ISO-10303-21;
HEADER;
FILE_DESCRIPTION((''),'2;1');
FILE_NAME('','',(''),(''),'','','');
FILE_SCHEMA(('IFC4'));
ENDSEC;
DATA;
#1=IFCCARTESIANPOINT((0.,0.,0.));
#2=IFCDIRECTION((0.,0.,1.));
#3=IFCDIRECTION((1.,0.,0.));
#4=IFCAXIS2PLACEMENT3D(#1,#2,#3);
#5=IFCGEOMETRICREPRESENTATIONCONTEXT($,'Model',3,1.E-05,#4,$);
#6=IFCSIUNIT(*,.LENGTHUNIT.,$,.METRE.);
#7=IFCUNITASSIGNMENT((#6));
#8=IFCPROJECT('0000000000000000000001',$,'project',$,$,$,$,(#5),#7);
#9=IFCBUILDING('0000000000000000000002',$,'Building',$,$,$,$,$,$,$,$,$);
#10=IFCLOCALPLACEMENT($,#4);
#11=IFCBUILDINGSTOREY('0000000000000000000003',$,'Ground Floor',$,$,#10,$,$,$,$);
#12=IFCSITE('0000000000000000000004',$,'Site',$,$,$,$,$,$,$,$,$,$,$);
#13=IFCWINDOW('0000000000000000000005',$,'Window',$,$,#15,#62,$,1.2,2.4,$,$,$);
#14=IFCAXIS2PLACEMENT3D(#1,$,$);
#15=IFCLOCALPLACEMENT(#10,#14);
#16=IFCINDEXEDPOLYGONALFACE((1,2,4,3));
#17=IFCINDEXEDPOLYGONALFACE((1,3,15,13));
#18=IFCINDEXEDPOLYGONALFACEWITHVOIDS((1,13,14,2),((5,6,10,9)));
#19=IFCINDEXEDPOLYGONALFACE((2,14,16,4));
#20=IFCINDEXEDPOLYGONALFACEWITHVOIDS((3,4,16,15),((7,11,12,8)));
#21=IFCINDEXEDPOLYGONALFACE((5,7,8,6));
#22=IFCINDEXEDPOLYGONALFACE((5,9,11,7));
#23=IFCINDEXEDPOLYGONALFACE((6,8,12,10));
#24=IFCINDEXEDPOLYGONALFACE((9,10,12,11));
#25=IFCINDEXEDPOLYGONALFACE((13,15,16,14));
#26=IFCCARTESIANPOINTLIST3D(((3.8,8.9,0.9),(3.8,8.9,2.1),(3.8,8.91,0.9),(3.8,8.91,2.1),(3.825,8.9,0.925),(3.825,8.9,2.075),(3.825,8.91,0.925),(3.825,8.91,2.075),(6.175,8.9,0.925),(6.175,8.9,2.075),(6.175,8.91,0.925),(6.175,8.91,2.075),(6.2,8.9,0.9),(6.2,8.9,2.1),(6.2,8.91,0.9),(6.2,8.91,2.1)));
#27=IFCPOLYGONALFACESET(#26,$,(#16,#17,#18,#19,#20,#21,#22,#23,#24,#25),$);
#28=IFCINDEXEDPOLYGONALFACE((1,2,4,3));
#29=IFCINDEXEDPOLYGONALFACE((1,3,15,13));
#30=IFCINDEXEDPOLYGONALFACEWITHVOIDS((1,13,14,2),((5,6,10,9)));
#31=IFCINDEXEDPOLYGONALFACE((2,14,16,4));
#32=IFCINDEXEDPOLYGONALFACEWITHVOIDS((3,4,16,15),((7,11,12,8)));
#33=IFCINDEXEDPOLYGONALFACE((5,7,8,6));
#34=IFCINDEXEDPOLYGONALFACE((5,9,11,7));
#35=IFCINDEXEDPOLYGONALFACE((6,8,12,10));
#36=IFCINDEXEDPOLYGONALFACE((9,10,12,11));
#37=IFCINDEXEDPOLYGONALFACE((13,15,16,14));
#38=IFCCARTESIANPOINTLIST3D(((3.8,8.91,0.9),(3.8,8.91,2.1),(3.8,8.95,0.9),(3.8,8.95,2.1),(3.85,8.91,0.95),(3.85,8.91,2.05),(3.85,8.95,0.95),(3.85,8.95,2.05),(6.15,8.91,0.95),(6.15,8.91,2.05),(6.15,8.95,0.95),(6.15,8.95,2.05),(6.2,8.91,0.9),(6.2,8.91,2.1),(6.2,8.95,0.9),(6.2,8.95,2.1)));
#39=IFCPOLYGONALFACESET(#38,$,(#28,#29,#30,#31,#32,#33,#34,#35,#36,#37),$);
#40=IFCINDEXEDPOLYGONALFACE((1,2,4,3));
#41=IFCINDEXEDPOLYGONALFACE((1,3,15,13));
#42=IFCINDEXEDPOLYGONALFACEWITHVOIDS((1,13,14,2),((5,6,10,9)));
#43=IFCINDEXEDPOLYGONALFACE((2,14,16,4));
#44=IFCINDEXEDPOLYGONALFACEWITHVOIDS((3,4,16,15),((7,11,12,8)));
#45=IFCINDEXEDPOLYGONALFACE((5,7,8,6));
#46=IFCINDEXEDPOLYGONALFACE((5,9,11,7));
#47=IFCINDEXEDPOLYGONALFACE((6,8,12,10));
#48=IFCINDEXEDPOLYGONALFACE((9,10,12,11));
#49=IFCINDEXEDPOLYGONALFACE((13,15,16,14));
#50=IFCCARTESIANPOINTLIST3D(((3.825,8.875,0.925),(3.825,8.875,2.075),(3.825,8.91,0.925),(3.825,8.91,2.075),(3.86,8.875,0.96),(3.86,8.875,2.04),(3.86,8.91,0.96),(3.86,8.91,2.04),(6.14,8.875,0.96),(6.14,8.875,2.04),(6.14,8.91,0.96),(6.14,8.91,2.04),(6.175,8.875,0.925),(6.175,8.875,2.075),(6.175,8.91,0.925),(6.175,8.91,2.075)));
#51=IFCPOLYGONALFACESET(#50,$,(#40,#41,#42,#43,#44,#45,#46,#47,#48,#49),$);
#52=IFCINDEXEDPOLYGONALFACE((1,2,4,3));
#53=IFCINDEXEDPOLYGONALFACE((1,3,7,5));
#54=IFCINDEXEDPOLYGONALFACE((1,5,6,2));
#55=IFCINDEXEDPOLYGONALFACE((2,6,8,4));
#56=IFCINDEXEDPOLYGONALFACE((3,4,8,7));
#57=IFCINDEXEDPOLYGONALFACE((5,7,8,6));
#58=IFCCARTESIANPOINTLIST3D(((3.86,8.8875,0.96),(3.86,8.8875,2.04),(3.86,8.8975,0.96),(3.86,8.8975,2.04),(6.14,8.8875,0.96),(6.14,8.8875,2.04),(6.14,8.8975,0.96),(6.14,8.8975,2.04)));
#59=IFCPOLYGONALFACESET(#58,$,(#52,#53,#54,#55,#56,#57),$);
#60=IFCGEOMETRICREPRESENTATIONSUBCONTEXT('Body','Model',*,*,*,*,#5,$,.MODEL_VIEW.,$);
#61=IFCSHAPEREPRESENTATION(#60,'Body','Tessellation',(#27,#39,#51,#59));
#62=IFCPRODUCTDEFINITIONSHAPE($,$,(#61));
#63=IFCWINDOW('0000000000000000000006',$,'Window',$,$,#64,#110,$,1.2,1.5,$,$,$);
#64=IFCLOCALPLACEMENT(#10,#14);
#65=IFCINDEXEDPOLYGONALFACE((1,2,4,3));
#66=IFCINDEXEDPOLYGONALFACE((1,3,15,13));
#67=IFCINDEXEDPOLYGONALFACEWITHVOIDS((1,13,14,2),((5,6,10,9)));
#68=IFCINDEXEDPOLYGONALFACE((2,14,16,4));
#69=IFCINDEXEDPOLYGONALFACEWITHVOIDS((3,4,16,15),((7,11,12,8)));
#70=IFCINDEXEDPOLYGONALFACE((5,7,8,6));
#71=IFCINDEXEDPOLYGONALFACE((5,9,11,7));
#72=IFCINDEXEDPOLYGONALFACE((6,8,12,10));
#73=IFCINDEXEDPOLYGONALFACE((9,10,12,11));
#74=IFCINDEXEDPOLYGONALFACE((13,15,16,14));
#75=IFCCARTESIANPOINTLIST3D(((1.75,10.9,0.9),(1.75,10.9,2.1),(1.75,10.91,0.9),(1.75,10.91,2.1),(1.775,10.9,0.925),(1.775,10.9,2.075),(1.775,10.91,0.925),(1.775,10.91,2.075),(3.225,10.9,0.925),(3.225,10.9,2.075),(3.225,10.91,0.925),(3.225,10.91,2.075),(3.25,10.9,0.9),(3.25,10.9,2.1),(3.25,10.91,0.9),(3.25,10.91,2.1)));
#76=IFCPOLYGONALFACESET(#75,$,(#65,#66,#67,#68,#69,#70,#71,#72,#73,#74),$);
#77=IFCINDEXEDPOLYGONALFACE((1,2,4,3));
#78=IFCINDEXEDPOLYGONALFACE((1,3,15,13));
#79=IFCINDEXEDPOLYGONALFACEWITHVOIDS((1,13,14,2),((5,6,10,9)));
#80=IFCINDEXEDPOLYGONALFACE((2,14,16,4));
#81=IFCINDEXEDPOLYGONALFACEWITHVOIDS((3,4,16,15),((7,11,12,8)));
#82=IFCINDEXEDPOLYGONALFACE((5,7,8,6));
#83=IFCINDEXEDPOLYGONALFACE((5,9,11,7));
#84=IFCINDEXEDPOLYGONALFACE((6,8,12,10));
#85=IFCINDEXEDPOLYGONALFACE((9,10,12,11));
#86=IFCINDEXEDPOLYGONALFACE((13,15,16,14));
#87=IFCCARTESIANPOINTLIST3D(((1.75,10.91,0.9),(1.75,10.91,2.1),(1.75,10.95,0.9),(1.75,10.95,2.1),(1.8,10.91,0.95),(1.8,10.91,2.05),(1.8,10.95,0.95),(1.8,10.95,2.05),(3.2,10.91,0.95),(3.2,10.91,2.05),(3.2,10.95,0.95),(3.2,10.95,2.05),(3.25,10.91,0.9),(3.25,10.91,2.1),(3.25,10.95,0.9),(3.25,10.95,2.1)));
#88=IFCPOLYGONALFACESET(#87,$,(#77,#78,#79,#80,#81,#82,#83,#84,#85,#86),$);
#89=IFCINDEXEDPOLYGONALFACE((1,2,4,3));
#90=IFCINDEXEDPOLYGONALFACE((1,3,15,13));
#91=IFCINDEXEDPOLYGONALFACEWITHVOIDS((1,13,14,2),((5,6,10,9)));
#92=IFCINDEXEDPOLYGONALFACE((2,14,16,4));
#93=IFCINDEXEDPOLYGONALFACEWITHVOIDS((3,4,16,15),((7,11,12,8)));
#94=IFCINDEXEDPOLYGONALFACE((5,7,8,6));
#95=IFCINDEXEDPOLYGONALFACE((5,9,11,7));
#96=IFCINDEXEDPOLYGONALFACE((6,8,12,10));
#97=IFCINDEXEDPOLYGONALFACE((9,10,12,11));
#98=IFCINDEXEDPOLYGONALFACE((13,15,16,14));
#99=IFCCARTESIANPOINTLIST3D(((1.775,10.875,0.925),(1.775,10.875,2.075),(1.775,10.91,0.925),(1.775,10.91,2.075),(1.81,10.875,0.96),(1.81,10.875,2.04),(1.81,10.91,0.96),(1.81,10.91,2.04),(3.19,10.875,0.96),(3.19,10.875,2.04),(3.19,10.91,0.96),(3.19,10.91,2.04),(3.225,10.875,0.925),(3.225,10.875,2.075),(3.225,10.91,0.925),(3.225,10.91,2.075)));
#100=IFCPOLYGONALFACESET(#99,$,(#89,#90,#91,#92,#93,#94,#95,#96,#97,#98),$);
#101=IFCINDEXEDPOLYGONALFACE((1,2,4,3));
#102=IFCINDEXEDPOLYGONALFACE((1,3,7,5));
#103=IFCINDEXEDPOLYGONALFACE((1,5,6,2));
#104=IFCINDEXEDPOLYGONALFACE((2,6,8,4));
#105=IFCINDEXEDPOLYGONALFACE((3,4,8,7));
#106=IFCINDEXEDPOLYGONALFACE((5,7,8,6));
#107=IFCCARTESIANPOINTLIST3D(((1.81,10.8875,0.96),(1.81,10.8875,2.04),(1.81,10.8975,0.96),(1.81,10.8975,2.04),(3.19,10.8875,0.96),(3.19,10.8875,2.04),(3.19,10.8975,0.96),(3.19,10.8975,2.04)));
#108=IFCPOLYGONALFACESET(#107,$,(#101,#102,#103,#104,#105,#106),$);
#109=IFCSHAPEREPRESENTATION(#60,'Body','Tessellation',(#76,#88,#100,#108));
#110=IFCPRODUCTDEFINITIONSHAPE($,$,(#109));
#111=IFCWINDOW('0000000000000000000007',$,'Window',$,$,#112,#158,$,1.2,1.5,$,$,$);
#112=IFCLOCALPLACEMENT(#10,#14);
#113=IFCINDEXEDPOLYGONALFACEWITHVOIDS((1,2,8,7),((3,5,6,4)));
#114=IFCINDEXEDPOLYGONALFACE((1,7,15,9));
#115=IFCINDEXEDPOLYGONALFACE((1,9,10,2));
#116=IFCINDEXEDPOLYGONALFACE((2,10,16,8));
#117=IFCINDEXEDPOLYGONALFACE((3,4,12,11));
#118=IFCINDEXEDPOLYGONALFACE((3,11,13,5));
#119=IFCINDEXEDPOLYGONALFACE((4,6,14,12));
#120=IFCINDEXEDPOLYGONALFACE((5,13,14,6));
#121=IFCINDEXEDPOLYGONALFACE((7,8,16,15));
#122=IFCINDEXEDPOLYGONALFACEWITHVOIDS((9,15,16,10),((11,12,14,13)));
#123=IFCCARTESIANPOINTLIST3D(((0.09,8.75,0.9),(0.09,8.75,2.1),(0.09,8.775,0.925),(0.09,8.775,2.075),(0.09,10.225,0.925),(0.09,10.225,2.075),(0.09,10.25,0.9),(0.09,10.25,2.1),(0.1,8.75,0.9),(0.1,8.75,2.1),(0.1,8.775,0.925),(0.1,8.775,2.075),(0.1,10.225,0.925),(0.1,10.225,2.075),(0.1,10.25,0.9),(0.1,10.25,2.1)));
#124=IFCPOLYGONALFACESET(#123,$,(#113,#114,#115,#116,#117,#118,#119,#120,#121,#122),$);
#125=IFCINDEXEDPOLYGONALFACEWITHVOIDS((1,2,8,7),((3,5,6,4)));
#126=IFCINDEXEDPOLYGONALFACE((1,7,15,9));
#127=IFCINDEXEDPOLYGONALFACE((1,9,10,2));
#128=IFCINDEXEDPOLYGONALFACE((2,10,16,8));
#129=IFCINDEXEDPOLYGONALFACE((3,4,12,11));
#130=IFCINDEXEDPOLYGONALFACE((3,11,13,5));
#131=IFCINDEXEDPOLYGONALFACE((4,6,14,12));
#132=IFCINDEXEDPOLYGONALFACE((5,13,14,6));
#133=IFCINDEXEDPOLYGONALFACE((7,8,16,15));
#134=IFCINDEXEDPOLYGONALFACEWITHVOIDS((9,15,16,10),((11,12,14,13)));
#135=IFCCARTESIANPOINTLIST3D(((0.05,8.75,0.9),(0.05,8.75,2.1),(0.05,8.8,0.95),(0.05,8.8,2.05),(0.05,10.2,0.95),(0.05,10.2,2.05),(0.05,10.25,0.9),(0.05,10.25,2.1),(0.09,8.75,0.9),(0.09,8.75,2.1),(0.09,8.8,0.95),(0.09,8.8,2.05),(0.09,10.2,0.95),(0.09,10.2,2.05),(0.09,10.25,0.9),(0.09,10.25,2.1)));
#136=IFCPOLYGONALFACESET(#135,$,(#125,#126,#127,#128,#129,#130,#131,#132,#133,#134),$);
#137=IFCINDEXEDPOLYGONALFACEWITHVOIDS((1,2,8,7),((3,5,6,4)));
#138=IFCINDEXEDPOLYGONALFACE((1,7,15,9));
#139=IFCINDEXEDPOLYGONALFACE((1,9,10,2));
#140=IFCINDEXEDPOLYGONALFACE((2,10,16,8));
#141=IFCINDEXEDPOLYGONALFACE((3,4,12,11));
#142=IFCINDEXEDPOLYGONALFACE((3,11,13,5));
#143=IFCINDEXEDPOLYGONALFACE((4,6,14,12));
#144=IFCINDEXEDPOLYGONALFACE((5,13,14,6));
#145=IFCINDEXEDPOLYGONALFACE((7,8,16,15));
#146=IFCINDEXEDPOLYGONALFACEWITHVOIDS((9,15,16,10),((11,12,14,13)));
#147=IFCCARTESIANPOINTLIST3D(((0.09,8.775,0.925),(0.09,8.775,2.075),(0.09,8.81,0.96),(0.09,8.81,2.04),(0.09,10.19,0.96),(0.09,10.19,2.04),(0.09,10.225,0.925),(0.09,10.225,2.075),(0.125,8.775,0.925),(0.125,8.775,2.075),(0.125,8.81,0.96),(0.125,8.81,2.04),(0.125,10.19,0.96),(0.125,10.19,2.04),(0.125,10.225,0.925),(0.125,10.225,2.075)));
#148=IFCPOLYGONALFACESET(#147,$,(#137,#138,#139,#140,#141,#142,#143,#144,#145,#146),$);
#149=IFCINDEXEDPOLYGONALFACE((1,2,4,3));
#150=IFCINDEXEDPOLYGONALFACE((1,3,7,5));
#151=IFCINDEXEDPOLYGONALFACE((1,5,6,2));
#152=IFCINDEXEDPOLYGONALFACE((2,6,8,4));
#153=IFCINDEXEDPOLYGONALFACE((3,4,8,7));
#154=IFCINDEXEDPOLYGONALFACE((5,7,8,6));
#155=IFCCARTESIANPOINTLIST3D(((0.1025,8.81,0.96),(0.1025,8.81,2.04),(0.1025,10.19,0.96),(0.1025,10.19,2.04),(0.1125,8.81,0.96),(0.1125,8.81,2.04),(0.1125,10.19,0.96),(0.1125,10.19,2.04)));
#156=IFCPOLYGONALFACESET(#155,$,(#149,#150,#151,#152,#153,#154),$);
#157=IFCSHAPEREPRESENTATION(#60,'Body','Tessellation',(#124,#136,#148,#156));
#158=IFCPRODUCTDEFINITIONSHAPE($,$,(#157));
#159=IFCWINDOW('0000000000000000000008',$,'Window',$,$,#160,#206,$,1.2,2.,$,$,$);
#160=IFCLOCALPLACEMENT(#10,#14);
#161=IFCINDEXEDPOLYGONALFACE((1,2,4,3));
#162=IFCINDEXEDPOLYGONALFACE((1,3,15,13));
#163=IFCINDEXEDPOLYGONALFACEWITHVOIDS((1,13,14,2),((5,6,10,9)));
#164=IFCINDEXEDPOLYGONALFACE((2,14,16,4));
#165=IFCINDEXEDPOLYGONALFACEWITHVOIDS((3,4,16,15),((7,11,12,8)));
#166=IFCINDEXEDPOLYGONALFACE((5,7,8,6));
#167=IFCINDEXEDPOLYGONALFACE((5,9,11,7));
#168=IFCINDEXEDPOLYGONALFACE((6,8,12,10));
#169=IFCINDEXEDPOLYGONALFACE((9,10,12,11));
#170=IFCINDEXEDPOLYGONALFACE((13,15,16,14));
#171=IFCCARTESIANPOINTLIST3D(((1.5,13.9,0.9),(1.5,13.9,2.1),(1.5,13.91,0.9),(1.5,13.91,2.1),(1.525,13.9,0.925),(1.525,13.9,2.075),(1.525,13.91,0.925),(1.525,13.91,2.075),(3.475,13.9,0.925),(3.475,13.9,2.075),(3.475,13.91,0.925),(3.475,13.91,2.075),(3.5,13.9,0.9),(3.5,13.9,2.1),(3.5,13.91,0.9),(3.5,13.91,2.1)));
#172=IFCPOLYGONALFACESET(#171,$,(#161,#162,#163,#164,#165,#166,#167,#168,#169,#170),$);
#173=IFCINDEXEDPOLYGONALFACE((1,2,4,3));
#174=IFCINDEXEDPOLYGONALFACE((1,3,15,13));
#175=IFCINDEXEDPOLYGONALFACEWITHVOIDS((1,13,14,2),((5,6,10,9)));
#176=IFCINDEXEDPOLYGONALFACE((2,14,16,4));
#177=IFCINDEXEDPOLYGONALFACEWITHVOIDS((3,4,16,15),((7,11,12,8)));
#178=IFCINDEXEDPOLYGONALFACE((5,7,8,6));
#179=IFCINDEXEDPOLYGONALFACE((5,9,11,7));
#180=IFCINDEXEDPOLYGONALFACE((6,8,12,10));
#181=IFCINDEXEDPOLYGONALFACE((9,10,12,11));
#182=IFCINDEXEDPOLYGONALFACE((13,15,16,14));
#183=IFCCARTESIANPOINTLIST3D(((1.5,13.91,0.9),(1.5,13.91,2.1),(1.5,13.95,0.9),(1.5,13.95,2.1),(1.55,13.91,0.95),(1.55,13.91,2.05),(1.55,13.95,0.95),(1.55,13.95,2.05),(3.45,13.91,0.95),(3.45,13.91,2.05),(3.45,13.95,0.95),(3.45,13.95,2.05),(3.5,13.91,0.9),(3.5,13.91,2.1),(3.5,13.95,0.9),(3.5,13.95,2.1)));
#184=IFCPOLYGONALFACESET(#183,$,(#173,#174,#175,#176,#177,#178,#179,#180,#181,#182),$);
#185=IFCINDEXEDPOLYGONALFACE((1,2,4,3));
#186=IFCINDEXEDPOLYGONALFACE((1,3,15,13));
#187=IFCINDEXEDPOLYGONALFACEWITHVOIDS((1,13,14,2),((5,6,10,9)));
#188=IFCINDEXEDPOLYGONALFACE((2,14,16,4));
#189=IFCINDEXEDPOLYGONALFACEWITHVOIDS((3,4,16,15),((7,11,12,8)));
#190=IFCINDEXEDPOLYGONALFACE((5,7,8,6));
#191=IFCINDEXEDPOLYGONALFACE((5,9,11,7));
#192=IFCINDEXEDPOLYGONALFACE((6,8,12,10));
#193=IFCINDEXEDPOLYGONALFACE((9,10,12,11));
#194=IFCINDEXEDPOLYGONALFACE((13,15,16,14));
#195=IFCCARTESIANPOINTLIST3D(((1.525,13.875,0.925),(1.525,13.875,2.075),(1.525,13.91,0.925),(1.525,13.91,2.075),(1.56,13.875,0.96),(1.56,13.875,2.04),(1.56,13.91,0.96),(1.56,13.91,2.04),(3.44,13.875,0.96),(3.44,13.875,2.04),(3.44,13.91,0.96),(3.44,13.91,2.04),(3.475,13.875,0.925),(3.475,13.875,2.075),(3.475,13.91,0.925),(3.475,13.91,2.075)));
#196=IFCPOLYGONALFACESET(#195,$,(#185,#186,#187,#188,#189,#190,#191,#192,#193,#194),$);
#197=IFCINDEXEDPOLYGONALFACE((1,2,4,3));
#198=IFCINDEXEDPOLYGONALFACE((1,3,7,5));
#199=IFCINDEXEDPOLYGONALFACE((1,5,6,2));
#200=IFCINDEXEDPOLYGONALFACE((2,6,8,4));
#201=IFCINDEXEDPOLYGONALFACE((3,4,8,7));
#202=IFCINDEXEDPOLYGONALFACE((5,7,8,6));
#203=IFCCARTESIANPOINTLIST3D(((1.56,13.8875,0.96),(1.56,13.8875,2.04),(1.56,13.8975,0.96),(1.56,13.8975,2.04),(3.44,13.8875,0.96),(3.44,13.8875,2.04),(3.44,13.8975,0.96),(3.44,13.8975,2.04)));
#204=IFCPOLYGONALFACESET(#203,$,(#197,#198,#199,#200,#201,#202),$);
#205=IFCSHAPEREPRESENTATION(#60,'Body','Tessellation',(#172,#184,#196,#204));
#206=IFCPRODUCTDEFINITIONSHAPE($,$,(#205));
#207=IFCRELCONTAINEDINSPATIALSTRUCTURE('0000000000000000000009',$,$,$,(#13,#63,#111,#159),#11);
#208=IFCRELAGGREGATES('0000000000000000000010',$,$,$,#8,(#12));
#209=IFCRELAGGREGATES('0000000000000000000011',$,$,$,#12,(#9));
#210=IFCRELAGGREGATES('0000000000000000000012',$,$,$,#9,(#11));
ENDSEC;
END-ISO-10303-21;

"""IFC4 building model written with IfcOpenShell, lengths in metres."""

from ifc_helpers import new_model, si_unit, frame, origin_with_axes, place, context, subcontext, project, spatial, line, indexed_curve, outline, extrude, element, save


model = new_model("IFC4")

# Units and contexts
model_context = context("Model", 3, precision=1e-05, world=origin_with_axes())
body_context = subcontext(model_context, "Body", "Model", "MODEL_VIEW")
ifc_project = project(units=[si_unit("LENGTHUNIT", "METRE")], contexts=[model_context])

# Site, building, storey
site = spatial("IfcSite", under=ifc_project, Name="Site")
building = spatial("IfcBuilding", under=site, Name="Building")
storey_placement = place(None, origin_with_axes())
storey = spatial("IfcBuildingStorey", under=building, at=storey_placement, Name="Ground Floor")

# Windows
window_1_placement = place(storey_placement, frame((6.2, 9.0, 0.9), z_axis=(0.0, 0.0, 1.0), x_axis=(-1.0, 0.0, 0.0)))
element("IfcWindow", 1, at=window_1_placement, inside=storey, Name="Window", OverallHeight=1.2, OverallWidth=2.4, context=body_context, shape_type="SweptSolid", body=[
    extrude(outline(indexed_curve([(0.0, 0.0), (2.4, 0.0), (2.4, 1.2), (0.0, 1.2)], segments=[line(1, 2, 3, 4, 1)]), holes=[indexed_curve([(0.025, 0.025), (2.375, 0.025), (2.375, 1.175), (0.025, 1.175)], segments=[line(1, 2, 3, 4, 1)])]), frame((0.0, 0.09, 0.0), z_axis=(0.0, -1.0, 0.0), x_axis=(1.0, 0.0, 0.0)), (0.0, 0.0, -1.0), 0.01),
    extrude(outline(indexed_curve([(0.0, 0.0), (2.4, 0.0), (2.4, 1.2), (0.0, 1.2)], segments=[line(1, 2, 3, 4, 1)]), holes=[indexed_curve([(0.05, 0.05), (2.35, 0.05), (2.35, 1.15), (0.05, 1.15)], segments=[line(1, 2, 3, 4, 1)])]), frame((0.0, 0.05, 0.0), z_axis=(0.0, -1.0, 0.0), x_axis=(1.0, 0.0, 0.0)), (0.0, 0.0, -1.0), 0.04),
    extrude(outline(indexed_curve([(0.0, 0.0), (2.35, 0.0), (2.35, 1.15), (0.0, 1.15)], segments=[line(1, 2, 3, 4, 1)]), holes=[indexed_curve([(0.035, 0.035), (2.315, 0.035), (2.315, 1.115), (0.035, 1.115)], segments=[line(1, 2, 3, 4, 1)])]), frame((0.025, 0.09, 0.025), z_axis=(0.0, -1.0, 0.0), x_axis=(1.0, 0.0, 0.0)), (0.0, 0.0, -1.0), 0.035),
    extrude(outline(indexed_curve([(0.035, 0.035), (2.315, 0.035), (2.315, 1.115), (0.035, 1.115)], segments=[line(1, 2, 3, 4, 1)])), frame((0.025, 0.1025, 0.025), z_axis=(0.0, -1.0, 0.0), x_axis=(1.0, 0.0, 0.0)), (0.0, 0.0, -1.0), 0.01),
])
for number, where, z_axis, x_axis, name in (
    (2, (3.25, 11.0, 0.9), (0.0, 0.0, 1.0), (-1.0, 0.0, 0.0), "Window"),
    (3, (0.0, 10.25, 0.9), (0.0, 0.0, 1.0), (0.0, -1.0, 0.0), "Window"),
):
    element("IfcWindow", number, at=place(storey_placement, frame(where, z_axis=z_axis, x_axis=x_axis)), inside=storey, Name=name, OverallHeight=1.2, OverallWidth=1.5, context=body_context, shape_type="SweptSolid", body=[
        extrude(outline(indexed_curve([(0.0, 0.0), (1.5, 0.0), (1.5, 1.2), (0.0, 1.2)], segments=[line(1, 2, 3, 4, 1)]), holes=[indexed_curve([(0.025, 0.025), (1.475, 0.025), (1.475, 1.175), (0.025, 1.175)], segments=[line(1, 2, 3, 4, 1)])]), frame((0.0, 0.09, 0.0), z_axis=(0.0, -1.0, 0.0), x_axis=(1.0, 0.0, 0.0)), (0.0, 0.0, -1.0), 0.01),
        extrude(outline(indexed_curve([(0.0, 0.0), (1.5, 0.0), (1.5, 1.2), (0.0, 1.2)], segments=[line(1, 2, 3, 4, 1)]), holes=[indexed_curve([(0.05, 0.05), (1.45, 0.05), (1.45, 1.15), (0.05, 1.15)], segments=[line(1, 2, 3, 4, 1)])]), frame((0.0, 0.05, 0.0), z_axis=(0.0, -1.0, 0.0), x_axis=(1.0, 0.0, 0.0)), (0.0, 0.0, -1.0), 0.04),
        extrude(outline(indexed_curve([(0.0, 0.0), (1.45, 0.0), (1.45, 1.15), (0.0, 1.15)], segments=[line(1, 2, 3, 4, 1)]), holes=[indexed_curve([(0.035, 0.035), (1.415, 0.035), (1.415, 1.115), (0.035, 1.115)], segments=[line(1, 2, 3, 4, 1)])]), frame((0.025, 0.09, 0.025), z_axis=(0.0, -1.0, 0.0), x_axis=(1.0, 0.0, 0.0)), (0.0, 0.0, -1.0), 0.035),
        extrude(outline(indexed_curve([(0.035, 0.035), (1.415, 0.035), (1.415, 1.115), (0.035, 1.115)], segments=[line(1, 2, 3, 4, 1)])), frame((0.025, 0.1025, 0.025), z_axis=(0.0, -1.0, 0.0), x_axis=(1.0, 0.0, 0.0)), (0.0, 0.0, -1.0), 0.01),
    ])
window_2_placement = place(storey_placement, frame((3.5, 14.0, 0.9), z_axis=(0.0, 0.0, 1.0), x_axis=(-1.0, 0.0, 0.0)))
element("IfcWindow", 4, at=window_2_placement, inside=storey, Name="Window", OverallHeight=1.2, OverallWidth=2.0, context=body_context, shape_type="SweptSolid", body=[
    extrude(outline(indexed_curve([(0.0, 0.0), (2.0, 0.0), (2.0, 1.2), (0.0, 1.2)], segments=[line(1, 2, 3, 4, 1)]), holes=[indexed_curve([(0.025, 0.025), (1.975, 0.025), (1.975, 1.175), (0.025, 1.175)], segments=[line(1, 2, 3, 4, 1)])]), frame((0.0, 0.09, 0.0), z_axis=(0.0, -1.0, 0.0), x_axis=(1.0, 0.0, 0.0)), (0.0, 0.0, -1.0), 0.01),
    extrude(outline(indexed_curve([(0.0, 0.0), (2.0, 0.0), (2.0, 1.2), (0.0, 1.2)], segments=[line(1, 2, 3, 4, 1)]), holes=[indexed_curve([(0.05, 0.05), (1.95, 0.05), (1.95, 1.15), (0.05, 1.15)], segments=[line(1, 2, 3, 4, 1)])]), frame((0.0, 0.05, 0.0), z_axis=(0.0, -1.0, 0.0), x_axis=(1.0, 0.0, 0.0)), (0.0, 0.0, -1.0), 0.04),
    extrude(outline(indexed_curve([(0.0, 0.0), (1.95, 0.0), (1.95, 1.15), (0.0, 1.15)], segments=[line(1, 2, 3, 4, 1)]), holes=[indexed_curve([(0.035, 0.035), (1.915, 0.035), (1.915, 1.115), (0.035, 1.115)], segments=[line(1, 2, 3, 4, 1)])]), frame((0.025, 0.09, 0.025), z_axis=(0.0, -1.0, 0.0), x_axis=(1.0, 0.0, 0.0)), (0.0, 0.0, -1.0), 0.035),
    extrude(outline(indexed_curve([(0.035, 0.035), (1.915, 0.035), (1.915, 1.115), (0.035, 1.115)], segments=[line(1, 2, 3, 4, 1)])), frame((0.025, 0.1025, 0.025), z_axis=(0.0, -1.0, 0.0), x_axis=(1.0, 0.0, 0.0)), (0.0, 0.0, -1.0), 0.01),
])

save(model, "model.ifc")
